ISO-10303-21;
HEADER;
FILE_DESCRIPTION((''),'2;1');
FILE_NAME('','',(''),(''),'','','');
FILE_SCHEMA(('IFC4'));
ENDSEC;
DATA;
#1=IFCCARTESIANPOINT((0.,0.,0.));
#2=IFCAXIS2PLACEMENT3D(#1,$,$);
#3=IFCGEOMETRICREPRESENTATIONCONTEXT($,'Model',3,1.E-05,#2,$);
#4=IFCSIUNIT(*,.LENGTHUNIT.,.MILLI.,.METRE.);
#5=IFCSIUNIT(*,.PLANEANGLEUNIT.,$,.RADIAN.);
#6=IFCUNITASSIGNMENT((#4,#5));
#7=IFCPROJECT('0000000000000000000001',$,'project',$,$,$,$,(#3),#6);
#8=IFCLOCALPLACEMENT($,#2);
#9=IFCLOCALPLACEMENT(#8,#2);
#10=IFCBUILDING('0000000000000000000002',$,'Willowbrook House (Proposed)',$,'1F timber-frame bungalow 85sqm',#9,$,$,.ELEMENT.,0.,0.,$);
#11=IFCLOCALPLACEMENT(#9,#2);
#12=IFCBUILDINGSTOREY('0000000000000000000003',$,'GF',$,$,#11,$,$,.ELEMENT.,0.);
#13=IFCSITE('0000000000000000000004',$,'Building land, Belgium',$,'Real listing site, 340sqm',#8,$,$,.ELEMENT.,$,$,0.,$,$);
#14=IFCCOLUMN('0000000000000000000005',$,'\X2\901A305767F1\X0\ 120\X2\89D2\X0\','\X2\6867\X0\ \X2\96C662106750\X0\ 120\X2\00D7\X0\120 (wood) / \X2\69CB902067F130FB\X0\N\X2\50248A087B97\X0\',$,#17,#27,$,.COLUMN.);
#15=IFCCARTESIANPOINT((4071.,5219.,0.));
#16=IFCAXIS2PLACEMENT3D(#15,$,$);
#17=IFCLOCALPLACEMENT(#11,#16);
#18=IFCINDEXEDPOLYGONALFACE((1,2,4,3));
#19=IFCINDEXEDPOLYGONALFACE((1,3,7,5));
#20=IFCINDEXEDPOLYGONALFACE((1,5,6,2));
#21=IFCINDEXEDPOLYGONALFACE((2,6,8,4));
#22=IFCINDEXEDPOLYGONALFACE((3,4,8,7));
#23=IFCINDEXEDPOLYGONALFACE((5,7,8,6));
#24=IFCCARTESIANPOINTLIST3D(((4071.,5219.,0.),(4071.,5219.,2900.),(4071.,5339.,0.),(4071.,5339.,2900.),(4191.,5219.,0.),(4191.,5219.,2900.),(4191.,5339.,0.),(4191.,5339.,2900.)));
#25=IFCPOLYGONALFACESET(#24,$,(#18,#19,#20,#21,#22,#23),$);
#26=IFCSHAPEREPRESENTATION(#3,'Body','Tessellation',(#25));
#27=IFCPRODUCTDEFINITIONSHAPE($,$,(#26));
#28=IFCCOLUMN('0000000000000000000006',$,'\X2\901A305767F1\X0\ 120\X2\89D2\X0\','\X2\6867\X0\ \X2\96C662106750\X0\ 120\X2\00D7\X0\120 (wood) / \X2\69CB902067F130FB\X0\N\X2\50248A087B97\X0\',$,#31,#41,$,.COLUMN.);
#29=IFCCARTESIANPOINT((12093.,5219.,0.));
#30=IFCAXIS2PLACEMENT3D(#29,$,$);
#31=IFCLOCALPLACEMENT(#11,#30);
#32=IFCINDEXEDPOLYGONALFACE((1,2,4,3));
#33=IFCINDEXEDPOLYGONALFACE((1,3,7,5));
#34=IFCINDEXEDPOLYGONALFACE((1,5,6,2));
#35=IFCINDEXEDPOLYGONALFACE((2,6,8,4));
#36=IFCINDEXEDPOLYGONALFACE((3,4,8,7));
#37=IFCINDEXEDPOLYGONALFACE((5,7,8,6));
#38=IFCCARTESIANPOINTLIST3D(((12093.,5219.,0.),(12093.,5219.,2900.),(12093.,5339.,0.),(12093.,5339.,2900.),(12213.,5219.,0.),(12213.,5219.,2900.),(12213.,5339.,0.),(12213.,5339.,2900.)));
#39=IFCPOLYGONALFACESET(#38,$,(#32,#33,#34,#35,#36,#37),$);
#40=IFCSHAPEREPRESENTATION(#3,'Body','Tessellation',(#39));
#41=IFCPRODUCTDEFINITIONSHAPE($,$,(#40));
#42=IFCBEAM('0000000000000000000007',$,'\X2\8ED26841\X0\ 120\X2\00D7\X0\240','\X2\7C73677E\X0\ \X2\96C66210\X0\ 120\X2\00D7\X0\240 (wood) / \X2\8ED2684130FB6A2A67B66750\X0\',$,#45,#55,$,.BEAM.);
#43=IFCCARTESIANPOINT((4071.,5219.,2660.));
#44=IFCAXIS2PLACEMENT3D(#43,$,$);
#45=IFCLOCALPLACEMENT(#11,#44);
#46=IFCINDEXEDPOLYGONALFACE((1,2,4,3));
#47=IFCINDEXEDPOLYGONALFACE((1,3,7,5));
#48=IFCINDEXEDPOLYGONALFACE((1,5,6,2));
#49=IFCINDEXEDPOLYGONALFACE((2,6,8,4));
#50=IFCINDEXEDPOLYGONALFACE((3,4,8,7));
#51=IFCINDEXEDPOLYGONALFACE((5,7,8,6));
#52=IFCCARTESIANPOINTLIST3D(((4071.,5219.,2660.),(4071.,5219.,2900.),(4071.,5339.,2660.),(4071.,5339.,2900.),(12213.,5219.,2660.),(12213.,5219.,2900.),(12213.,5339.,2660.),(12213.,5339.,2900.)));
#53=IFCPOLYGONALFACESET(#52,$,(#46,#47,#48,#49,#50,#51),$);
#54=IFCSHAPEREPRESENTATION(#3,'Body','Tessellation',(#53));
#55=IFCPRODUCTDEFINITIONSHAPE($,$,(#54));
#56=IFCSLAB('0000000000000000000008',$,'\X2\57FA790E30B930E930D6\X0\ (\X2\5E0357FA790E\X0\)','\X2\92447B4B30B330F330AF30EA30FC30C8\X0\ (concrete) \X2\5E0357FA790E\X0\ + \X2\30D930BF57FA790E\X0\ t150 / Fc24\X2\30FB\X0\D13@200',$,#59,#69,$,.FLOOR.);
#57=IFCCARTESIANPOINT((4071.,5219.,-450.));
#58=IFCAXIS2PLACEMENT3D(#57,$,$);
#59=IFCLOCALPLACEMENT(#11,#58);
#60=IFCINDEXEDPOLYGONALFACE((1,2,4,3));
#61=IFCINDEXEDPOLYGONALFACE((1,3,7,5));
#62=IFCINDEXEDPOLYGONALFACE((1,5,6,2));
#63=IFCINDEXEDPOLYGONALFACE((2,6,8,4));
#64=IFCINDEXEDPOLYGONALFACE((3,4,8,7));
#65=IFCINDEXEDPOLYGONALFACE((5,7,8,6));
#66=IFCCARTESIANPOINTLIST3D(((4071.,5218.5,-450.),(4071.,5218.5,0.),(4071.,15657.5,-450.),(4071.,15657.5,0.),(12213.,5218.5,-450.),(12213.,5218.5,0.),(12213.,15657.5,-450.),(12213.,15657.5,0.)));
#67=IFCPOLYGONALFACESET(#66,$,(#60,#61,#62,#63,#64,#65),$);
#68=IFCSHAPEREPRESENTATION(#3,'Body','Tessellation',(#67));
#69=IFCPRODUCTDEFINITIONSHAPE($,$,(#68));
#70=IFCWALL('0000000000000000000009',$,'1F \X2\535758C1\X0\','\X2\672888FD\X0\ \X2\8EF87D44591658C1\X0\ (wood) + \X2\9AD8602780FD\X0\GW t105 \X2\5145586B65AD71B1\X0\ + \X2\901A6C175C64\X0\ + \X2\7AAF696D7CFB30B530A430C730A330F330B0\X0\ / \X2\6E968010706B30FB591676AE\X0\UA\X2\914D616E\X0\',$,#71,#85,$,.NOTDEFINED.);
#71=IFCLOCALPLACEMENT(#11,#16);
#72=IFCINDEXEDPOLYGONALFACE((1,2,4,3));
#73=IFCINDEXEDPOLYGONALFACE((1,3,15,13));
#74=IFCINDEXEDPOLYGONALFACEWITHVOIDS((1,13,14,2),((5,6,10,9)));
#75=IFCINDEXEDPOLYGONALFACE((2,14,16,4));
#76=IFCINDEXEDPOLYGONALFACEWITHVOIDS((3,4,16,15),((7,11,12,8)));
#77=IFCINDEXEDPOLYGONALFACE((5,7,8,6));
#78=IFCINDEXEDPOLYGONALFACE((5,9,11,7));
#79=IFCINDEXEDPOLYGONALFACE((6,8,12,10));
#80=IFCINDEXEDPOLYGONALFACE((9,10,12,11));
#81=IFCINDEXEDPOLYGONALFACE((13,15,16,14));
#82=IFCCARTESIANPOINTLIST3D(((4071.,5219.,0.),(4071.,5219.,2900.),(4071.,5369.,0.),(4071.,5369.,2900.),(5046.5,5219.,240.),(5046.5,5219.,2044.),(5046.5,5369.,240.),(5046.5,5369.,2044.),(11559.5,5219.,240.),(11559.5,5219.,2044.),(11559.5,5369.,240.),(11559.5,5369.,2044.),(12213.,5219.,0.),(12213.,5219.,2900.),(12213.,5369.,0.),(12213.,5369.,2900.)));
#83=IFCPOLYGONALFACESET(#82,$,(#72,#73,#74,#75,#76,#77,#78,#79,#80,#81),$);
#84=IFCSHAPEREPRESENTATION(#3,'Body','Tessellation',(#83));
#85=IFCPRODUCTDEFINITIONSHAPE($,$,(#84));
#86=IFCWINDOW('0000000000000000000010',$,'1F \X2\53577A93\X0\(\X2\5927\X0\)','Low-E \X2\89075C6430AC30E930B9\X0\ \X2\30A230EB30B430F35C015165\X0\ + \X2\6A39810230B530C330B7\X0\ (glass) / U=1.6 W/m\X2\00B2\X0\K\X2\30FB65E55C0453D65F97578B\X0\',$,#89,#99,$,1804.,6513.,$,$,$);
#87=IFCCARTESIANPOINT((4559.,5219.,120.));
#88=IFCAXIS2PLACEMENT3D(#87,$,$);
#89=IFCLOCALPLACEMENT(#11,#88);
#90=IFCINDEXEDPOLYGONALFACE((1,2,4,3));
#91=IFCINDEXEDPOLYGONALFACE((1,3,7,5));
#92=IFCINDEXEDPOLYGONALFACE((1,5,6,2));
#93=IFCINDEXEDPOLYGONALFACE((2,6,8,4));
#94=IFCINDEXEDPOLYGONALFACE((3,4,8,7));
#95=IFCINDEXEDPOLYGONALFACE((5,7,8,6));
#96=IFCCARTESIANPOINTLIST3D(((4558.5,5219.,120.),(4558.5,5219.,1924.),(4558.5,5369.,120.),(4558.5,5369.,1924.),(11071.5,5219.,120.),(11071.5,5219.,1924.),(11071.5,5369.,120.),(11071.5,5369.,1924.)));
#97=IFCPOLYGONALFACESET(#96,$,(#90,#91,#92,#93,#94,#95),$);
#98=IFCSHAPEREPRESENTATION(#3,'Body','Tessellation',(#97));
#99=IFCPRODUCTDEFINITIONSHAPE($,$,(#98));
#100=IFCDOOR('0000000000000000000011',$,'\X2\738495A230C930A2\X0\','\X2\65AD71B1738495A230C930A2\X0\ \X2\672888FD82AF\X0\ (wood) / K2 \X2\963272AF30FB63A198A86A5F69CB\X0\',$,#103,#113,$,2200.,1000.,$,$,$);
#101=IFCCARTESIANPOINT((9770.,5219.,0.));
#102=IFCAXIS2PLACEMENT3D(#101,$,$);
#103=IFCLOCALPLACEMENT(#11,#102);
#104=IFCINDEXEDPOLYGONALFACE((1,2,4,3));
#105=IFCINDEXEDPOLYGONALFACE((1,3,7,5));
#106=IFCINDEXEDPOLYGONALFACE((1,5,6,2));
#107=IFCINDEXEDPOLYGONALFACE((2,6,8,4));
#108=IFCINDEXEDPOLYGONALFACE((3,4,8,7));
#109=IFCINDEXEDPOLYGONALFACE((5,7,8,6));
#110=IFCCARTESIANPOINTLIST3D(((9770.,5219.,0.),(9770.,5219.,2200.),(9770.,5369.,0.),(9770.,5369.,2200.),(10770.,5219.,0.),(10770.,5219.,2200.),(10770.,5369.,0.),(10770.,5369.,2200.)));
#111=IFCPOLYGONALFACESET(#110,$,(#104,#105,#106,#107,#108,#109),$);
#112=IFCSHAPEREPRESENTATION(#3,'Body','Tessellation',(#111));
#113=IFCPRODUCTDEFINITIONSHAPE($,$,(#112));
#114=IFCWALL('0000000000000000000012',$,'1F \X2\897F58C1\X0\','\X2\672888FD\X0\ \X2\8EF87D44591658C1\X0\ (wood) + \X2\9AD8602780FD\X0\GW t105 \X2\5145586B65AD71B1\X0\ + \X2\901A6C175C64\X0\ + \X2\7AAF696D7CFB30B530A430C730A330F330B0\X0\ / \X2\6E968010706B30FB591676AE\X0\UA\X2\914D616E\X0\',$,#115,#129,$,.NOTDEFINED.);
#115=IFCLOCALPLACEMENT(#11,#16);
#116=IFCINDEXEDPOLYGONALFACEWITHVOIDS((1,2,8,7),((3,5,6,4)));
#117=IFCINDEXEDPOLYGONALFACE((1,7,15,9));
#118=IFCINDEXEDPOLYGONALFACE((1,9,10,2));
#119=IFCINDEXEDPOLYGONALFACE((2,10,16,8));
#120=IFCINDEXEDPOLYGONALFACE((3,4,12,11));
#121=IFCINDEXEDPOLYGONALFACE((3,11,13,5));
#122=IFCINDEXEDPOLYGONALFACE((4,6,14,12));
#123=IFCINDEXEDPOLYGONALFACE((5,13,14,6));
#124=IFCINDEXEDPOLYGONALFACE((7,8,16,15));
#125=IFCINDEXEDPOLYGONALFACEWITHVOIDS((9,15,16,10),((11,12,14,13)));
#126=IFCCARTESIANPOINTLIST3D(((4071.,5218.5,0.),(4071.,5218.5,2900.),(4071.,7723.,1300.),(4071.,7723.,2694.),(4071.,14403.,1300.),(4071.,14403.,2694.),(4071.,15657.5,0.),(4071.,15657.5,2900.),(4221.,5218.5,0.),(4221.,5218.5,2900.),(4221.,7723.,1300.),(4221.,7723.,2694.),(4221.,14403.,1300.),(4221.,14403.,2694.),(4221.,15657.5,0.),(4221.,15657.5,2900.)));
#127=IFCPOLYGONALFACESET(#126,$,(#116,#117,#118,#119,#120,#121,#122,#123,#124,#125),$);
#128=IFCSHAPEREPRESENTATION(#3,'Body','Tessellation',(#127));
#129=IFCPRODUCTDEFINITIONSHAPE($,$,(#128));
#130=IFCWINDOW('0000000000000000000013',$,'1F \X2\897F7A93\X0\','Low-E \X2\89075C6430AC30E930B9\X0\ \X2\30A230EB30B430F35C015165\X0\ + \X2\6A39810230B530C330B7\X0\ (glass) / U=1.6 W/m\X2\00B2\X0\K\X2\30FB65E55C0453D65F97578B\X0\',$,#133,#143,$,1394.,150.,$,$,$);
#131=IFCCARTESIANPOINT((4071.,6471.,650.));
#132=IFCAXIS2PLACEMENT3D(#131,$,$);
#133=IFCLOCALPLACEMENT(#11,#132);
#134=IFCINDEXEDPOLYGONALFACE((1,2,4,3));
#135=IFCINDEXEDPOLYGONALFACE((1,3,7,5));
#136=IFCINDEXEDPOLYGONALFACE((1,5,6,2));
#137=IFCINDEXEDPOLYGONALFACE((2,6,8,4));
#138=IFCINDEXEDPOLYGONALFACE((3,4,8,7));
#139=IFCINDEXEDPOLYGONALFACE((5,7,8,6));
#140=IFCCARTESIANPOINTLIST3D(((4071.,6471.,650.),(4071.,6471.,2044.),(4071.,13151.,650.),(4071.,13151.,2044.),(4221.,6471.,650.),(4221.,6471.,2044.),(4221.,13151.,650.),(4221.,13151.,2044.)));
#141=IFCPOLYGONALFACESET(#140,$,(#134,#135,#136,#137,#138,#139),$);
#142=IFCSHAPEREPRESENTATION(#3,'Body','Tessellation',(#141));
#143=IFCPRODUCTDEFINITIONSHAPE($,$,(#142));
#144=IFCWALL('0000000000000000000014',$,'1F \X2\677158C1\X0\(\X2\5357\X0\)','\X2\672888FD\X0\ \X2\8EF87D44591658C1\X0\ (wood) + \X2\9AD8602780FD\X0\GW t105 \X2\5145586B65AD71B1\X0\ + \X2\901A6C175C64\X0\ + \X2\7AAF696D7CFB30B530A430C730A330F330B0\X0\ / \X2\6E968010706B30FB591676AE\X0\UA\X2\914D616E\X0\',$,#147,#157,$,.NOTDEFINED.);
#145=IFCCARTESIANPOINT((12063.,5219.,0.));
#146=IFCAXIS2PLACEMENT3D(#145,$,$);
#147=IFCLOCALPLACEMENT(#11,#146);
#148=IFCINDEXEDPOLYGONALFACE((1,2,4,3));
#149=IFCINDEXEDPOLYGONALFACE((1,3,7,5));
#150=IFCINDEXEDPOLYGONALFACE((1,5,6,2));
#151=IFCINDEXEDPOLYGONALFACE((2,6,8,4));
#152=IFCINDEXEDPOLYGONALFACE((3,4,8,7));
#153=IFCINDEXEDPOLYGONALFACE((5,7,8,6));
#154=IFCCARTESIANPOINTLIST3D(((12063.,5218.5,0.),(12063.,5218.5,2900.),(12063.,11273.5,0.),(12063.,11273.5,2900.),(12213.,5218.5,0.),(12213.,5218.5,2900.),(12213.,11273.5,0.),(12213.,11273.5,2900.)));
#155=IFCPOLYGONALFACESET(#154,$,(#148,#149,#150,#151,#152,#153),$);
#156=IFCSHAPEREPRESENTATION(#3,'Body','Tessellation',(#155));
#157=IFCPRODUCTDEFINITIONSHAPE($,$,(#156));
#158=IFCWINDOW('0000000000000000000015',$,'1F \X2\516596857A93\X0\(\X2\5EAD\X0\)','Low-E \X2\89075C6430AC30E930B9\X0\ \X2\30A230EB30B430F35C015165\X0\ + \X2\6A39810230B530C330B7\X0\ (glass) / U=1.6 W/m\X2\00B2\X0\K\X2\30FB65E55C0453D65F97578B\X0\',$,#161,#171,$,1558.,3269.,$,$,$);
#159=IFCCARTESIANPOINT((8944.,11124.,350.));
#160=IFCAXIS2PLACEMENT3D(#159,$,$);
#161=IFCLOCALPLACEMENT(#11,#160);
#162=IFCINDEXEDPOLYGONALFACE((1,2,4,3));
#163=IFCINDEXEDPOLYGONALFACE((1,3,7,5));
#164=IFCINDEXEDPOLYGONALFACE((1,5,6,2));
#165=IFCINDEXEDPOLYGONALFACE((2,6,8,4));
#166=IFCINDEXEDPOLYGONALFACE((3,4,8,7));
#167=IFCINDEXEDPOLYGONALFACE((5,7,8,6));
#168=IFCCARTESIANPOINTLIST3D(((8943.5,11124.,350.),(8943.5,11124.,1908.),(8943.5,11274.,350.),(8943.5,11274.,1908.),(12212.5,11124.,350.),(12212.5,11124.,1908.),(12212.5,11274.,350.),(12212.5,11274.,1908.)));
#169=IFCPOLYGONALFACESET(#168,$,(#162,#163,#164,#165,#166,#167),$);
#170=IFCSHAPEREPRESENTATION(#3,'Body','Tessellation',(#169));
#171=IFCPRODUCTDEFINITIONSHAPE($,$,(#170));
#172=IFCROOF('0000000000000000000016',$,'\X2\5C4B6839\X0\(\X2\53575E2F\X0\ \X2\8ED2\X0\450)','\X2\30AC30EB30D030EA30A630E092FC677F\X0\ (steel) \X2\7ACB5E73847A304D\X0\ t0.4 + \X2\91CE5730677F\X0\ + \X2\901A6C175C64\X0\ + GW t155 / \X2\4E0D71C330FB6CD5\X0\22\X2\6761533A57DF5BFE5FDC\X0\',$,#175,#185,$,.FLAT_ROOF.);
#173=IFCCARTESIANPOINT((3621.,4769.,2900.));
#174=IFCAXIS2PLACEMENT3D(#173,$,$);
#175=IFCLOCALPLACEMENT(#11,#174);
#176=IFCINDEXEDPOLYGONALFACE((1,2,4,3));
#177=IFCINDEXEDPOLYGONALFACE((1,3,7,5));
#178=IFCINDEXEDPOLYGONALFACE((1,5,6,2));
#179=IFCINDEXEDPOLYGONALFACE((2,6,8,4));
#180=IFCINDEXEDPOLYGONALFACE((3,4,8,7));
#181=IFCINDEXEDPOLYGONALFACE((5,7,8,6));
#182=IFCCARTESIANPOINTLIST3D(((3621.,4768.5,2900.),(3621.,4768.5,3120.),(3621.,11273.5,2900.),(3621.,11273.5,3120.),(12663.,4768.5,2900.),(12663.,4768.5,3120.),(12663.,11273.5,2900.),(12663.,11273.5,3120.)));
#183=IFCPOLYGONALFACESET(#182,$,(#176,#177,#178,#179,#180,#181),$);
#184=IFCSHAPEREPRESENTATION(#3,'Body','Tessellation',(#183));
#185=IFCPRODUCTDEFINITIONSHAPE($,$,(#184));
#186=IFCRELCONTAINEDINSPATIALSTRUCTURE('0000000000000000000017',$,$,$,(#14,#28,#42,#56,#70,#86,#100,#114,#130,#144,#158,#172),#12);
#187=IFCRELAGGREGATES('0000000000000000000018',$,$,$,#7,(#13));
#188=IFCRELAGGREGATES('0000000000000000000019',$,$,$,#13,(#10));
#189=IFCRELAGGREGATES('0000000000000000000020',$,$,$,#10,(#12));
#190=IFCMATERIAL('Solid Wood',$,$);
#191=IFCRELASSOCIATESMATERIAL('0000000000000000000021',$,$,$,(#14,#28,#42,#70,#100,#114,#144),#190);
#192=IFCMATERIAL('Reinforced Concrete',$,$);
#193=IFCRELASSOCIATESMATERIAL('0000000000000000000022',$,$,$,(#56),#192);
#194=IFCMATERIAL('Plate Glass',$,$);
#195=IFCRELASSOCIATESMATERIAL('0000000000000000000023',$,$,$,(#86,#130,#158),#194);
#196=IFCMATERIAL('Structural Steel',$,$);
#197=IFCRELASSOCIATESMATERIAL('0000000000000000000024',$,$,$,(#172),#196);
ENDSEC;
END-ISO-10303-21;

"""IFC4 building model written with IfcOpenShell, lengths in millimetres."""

from ifc_helpers import new_model, si_unit, frame, frame_2d, origin, place, context, project, spatial, rectangle, extrude, material, element, fill, save


model = new_model("IFC4")

# Units and contexts
model_context = context("Model", 3, precision=1e-05, world=origin())
ifc_project = project(units=[si_unit("LENGTHUNIT", "METRE", prefix="MILLI"), si_unit("PLANEANGLEUNIT", "RADIAN")], contexts=[model_context])

# Site, building, storey
site_placement = place(None, origin())
site = spatial("IfcSite", under=ifc_project, at=site_placement, Name="Building land, Belgium", ObjectType="Real listing site, 340sqm", CompositionType="ELEMENT", RefElevation=0.0)
building_placement = place(site_placement, origin())
building = spatial("IfcBuilding", under=site, at=building_placement, Name="Willowbrook House (Proposed)", ObjectType="1F timber-frame bungalow 85sqm", CompositionType="ELEMENT", ElevationOfRefHeight=0.0, ElevationOfTerrain=0.0)
storey_placement = place(building_placement, origin())
storey = spatial("IfcBuildingStorey", under=building, at=storey_placement, Name="GF", CompositionType="ELEMENT", Elevation=0.0)

# Columns
ifc_material_1 = material(Name="Solid Wood")
column_1_placement = place(storey_placement, frame((4071.0, 5219.0, 0.0)))
element("IfcColumn", 1, at=column_1_placement, inside=storey, material=ifc_material_1, Name="通し柱 120角", Description="桧 集成材 120×120 (wood) / 構造柱・N値計算", PredefinedType="COLUMN", context=model_context, shape_type="SweptSolid", body=[
    extrude(rectangle(XDim=120.0, YDim=120.0, at=frame_2d((60.0, 60.0))), frame((4071.0, 5219.0, 0.0)), (0.0, 0.0, 1.0), 2900.0),
])
column_2_placement = place(storey_placement, frame((12093.0, 5219.0, 0.0)))
element("IfcColumn", 2, at=column_2_placement, inside=storey, material=ifc_material_1, Name="通し柱 120角", Description="桧 集成材 120×120 (wood) / 構造柱・N値計算", PredefinedType="COLUMN", context=model_context, shape_type="SweptSolid", body=[
    extrude(rectangle(XDim=120.0, YDim=120.0, at=frame_2d((60.0, 60.0))), frame((12093.0, 5219.0, 0.0)), (0.0, 0.0, 1.0), 2900.0),
])

# Beam
beam_1_placement = place(storey_placement, frame((4071.0, 5219.0, 2660.0)))
element("IfcBeam", 3, at=beam_1_placement, inside=storey, material=ifc_material_1, Name="軒桁 120×240", Description="米松 集成 120×240 (wood) / 軒桁・横架材", PredefinedType="BEAM", context=model_context, shape_type="SweptSolid", body=[
    extrude(rectangle(XDim=8142.0, YDim=120.0, at=frame_2d((4071.0, 60.0))), frame((4071.0, 5219.0, 2660.0)), (0.0, 0.0, 1.0), 240.0),
])

# Slab
ifc_material_2 = material(Name="Reinforced Concrete")
slab_1_placement = place(storey_placement, frame((4071.0, 5219.0, -450.0)))
element("IfcSlab", 4, at=slab_1_placement, inside=storey, material=ifc_material_2, Name="基礎スラブ (布基礎)", Description="鉄筋コンクリート (concrete) 布基礎 + ベタ基礎 t150 / Fc24・D13@200", PredefinedType="FLOOR", context=model_context, shape_type="SweptSolid", body=[
    extrude(rectangle(XDim=8142.0, YDim=10439.0, at=frame_2d((4071.0, 5219.0))), frame((4071.0, 5219.0, -450.0)), (0.0, 0.0, 1.0), 450.0),
])

# Wall, openings, window, door
wall_1_placement = place(storey_placement, frame((4071.0, 5219.0, 0.0)))
wall_1 = element("IfcWall", 5, at=wall_1_placement, inside=storey, material=ifc_material_1, Name="1F 南壁", Description="木製 軸組外壁 (wood) + 高性能GW t105 充填断熱 + 通気層 + 窯業系サイディング / 準耐火・外皮UA配慮", PredefinedType="NOTDEFINED", context=model_context, shape_type="SweptSolid", body=[
    extrude(rectangle(XDim=8142.0, YDim=150.0, at=frame_2d((4071.0, 75.0))), frame((4071.0, 5219.0, 0.0)), (0.0, 0.0, 1.0), 2900.0),
])
opening_1_placement = place(storey_placement, frame((4559.0, 5219.0, 120.0)))
opening_1 = element("IfcOpeningElement", 6, at=opening_1_placement, cuts=wall_1, PredefinedType="NOTDEFINED", context=model_context, shape_type="SweptSolid", body=[
    extrude(rectangle(XDim=6513.0, YDim=150.0, at=frame_2d((3256.0, 75.0))), frame((4559.0, 5219.0, 120.0)), (0.0, 0.0, 1.0), 1804.0),
])
opening_2_placement = place(storey_placement, frame((9770.0, 5219.0, 0.0)))
opening_2 = element("IfcOpeningElement", 7, at=opening_2_placement, cuts=wall_1, PredefinedType="NOTDEFINED", context=model_context, shape_type="SweptSolid", body=[
    extrude(rectangle(XDim=1000.0, YDim=150.0, at=frame_2d((500.0, 75.0))), frame((9770.0, 5219.0, 0.0)), (0.0, 0.0, 1.0), 2200.0),
])
ifc_material_3 = material(Name="Plate Glass")
window_1_placement = place(storey_placement, frame((4559.0, 5219.0, 120.0)))
window_1 = element("IfcWindow", 8, at=window_1_placement, inside=storey, material=ifc_material_3, Name="1F 南窓(大)", Description="Low-E 複層ガラス アルゴン封入 + 樹脂サッシ (glass) / U=1.6 W/m²K・日射取得型", OverallHeight=1804.0, OverallWidth=6513.0, context=model_context, shape_type="SweptSolid", body=[
    extrude(rectangle(XDim=6513.0, YDim=150.0, at=frame_2d((3256.0, 75.0))), frame((4559.0, 5219.0, 120.0)), (0.0, 0.0, 1.0), 1804.0),
])
fill(opening_1, window_1)
door_1_placement = place(storey_placement, frame((9770.0, 5219.0, 0.0)))
door_1 = element("IfcDoor", 9, at=door_1_placement, inside=storey, material=ifc_material_1, Name="玄関ドア", Description="断熱玄関ドア 木製芯 (wood) / K2 防犯・採風機構", OverallHeight=2200.0, OverallWidth=1000.0, context=model_context, shape_type="SweptSolid", body=[
    extrude(rectangle(XDim=1000.0, YDim=150.0, at=frame_2d((500.0, 75.0))), frame((9770.0, 5219.0, 0.0)), (0.0, 0.0, 1.0), 2200.0),
])
fill(opening_2, door_1)

# Walls, openings, windows
wall_2_placement = place(storey_placement, frame((4071.0, 5219.0, 0.0)))
wall_2 = element("IfcWall", 10, at=wall_2_placement, inside=storey, material=ifc_material_1, Name="1F 西壁", Description="木製 軸組外壁 (wood) + 高性能GW t105 充填断熱 + 通気層 + 窯業系サイディング / 準耐火・外皮UA配慮", PredefinedType="NOTDEFINED", context=model_context, shape_type="SweptSolid", body=[
    extrude(rectangle(XDim=150.0, YDim=10439.0, at=frame_2d((75.0, 5219.0))), frame((4071.0, 5219.0, 0.0)), (0.0, 0.0, 1.0), 2900.0),
])
opening_3_placement = place(storey_placement, frame((4071.0, 6471.0, 650.0)))
opening_3 = element("IfcOpeningElement", 11, at=opening_3_placement, cuts=wall_2, PredefinedType="NOTDEFINED", context=model_context, shape_type="SweptSolid", body=[
    extrude(rectangle(XDim=150.0, YDim=6680.0, at=frame_2d((75.0, 3340.0))), frame((4071.0, 6471.0, 650.0)), (0.0, 0.0, 1.0), 1394.0),
])
window_2_placement = place(storey_placement, frame((4071.0, 6471.0, 650.0)))
window_2 = element("IfcWindow", 12, at=window_2_placement, inside=storey, material=ifc_material_3, Name="1F 西窓", Description="Low-E 複層ガラス アルゴン封入 + 樹脂サッシ (glass) / U=1.6 W/m²K・日射取得型", OverallHeight=1394.0, OverallWidth=150.0, context=model_context, shape_type="SweptSolid", body=[
    extrude(rectangle(XDim=150.0, YDim=6680.0, at=frame_2d((75.0, 3340.0))), frame((4071.0, 6471.0, 650.0)), (0.0, 0.0, 1.0), 1394.0),
])
fill(opening_3, window_2)
wall_3_placement = place(storey_placement, frame((12063.0, 5219.0, 0.0)))
wall_3 = element("IfcWall", 13, at=wall_3_placement, inside=storey, material=ifc_material_1, Name="1F 東壁(南)", Description="木製 軸組外壁 (wood) + 高性能GW t105 充填断熱 + 通気層 + 窯業系サイディング / 準耐火・外皮UA配慮", PredefinedType="NOTDEFINED", context=model_context, shape_type="SweptSolid", body=[
    extrude(rectangle(XDim=150.0, YDim=6055.0, at=frame_2d((75.0, 3027.0))), frame((12063.0, 5219.0, 0.0)), (0.0, 0.0, 1.0), 2900.0),
])
opening_4_placement = place(storey_placement, frame((8944.0, 11124.0, 350.0)))
opening_4 = element("IfcOpeningElement", 14, at=opening_4_placement, cuts=wall_3, PredefinedType="NOTDEFINED", context=model_context, shape_type="SweptSolid", body=[
    extrude(rectangle(XDim=3269.0, YDim=150.0, at=frame_2d((1634.0, 75.0))), frame((8944.0, 11124.0, 350.0)), (0.0, 0.0, 1.0), 1558.0),
])
window_3_placement = place(storey_placement, frame((8944.0, 11124.0, 350.0)))
window_3 = element("IfcWindow", 15, at=window_3_placement, inside=storey, material=ifc_material_3, Name="1F 入隅窓(庭)", Description="Low-E 複層ガラス アルゴン封入 + 樹脂サッシ (glass) / U=1.6 W/m²K・日射取得型", OverallHeight=1558.0, OverallWidth=3269.0, context=model_context, shape_type="SweptSolid", body=[
    extrude(rectangle(XDim=3269.0, YDim=150.0, at=frame_2d((1634.0, 75.0))), frame((8944.0, 11124.0, 350.0)), (0.0, 0.0, 1.0), 1558.0),
])
fill(opening_4, window_3)

# Roof
ifc_material_4 = material(Name="Structural Steel")
roof_placement = place(storey_placement, frame((3621.0, 4769.0, 2900.0)))
element("IfcRoof", 16, at=roof_placement, inside=storey, material=ifc_material_4, Name="屋根(南帯 軒450)", Description="ガルバリウム鋼板 (steel) 立平葺き t0.4 + 野地板 + 通気層 + GW t155 / 不燃・法22条区域対応", PredefinedType="FLAT_ROOF", context=model_context, shape_type="SweptSolid", body=[
    extrude(rectangle(XDim=9042.0, YDim=6505.0, at=frame_2d((4521.0, 3252.0))), frame((3621.0, 4769.0, 2900.0)), (0.0, 0.0, 1.0), 220.0),
])

save(model, "model.ifc")
